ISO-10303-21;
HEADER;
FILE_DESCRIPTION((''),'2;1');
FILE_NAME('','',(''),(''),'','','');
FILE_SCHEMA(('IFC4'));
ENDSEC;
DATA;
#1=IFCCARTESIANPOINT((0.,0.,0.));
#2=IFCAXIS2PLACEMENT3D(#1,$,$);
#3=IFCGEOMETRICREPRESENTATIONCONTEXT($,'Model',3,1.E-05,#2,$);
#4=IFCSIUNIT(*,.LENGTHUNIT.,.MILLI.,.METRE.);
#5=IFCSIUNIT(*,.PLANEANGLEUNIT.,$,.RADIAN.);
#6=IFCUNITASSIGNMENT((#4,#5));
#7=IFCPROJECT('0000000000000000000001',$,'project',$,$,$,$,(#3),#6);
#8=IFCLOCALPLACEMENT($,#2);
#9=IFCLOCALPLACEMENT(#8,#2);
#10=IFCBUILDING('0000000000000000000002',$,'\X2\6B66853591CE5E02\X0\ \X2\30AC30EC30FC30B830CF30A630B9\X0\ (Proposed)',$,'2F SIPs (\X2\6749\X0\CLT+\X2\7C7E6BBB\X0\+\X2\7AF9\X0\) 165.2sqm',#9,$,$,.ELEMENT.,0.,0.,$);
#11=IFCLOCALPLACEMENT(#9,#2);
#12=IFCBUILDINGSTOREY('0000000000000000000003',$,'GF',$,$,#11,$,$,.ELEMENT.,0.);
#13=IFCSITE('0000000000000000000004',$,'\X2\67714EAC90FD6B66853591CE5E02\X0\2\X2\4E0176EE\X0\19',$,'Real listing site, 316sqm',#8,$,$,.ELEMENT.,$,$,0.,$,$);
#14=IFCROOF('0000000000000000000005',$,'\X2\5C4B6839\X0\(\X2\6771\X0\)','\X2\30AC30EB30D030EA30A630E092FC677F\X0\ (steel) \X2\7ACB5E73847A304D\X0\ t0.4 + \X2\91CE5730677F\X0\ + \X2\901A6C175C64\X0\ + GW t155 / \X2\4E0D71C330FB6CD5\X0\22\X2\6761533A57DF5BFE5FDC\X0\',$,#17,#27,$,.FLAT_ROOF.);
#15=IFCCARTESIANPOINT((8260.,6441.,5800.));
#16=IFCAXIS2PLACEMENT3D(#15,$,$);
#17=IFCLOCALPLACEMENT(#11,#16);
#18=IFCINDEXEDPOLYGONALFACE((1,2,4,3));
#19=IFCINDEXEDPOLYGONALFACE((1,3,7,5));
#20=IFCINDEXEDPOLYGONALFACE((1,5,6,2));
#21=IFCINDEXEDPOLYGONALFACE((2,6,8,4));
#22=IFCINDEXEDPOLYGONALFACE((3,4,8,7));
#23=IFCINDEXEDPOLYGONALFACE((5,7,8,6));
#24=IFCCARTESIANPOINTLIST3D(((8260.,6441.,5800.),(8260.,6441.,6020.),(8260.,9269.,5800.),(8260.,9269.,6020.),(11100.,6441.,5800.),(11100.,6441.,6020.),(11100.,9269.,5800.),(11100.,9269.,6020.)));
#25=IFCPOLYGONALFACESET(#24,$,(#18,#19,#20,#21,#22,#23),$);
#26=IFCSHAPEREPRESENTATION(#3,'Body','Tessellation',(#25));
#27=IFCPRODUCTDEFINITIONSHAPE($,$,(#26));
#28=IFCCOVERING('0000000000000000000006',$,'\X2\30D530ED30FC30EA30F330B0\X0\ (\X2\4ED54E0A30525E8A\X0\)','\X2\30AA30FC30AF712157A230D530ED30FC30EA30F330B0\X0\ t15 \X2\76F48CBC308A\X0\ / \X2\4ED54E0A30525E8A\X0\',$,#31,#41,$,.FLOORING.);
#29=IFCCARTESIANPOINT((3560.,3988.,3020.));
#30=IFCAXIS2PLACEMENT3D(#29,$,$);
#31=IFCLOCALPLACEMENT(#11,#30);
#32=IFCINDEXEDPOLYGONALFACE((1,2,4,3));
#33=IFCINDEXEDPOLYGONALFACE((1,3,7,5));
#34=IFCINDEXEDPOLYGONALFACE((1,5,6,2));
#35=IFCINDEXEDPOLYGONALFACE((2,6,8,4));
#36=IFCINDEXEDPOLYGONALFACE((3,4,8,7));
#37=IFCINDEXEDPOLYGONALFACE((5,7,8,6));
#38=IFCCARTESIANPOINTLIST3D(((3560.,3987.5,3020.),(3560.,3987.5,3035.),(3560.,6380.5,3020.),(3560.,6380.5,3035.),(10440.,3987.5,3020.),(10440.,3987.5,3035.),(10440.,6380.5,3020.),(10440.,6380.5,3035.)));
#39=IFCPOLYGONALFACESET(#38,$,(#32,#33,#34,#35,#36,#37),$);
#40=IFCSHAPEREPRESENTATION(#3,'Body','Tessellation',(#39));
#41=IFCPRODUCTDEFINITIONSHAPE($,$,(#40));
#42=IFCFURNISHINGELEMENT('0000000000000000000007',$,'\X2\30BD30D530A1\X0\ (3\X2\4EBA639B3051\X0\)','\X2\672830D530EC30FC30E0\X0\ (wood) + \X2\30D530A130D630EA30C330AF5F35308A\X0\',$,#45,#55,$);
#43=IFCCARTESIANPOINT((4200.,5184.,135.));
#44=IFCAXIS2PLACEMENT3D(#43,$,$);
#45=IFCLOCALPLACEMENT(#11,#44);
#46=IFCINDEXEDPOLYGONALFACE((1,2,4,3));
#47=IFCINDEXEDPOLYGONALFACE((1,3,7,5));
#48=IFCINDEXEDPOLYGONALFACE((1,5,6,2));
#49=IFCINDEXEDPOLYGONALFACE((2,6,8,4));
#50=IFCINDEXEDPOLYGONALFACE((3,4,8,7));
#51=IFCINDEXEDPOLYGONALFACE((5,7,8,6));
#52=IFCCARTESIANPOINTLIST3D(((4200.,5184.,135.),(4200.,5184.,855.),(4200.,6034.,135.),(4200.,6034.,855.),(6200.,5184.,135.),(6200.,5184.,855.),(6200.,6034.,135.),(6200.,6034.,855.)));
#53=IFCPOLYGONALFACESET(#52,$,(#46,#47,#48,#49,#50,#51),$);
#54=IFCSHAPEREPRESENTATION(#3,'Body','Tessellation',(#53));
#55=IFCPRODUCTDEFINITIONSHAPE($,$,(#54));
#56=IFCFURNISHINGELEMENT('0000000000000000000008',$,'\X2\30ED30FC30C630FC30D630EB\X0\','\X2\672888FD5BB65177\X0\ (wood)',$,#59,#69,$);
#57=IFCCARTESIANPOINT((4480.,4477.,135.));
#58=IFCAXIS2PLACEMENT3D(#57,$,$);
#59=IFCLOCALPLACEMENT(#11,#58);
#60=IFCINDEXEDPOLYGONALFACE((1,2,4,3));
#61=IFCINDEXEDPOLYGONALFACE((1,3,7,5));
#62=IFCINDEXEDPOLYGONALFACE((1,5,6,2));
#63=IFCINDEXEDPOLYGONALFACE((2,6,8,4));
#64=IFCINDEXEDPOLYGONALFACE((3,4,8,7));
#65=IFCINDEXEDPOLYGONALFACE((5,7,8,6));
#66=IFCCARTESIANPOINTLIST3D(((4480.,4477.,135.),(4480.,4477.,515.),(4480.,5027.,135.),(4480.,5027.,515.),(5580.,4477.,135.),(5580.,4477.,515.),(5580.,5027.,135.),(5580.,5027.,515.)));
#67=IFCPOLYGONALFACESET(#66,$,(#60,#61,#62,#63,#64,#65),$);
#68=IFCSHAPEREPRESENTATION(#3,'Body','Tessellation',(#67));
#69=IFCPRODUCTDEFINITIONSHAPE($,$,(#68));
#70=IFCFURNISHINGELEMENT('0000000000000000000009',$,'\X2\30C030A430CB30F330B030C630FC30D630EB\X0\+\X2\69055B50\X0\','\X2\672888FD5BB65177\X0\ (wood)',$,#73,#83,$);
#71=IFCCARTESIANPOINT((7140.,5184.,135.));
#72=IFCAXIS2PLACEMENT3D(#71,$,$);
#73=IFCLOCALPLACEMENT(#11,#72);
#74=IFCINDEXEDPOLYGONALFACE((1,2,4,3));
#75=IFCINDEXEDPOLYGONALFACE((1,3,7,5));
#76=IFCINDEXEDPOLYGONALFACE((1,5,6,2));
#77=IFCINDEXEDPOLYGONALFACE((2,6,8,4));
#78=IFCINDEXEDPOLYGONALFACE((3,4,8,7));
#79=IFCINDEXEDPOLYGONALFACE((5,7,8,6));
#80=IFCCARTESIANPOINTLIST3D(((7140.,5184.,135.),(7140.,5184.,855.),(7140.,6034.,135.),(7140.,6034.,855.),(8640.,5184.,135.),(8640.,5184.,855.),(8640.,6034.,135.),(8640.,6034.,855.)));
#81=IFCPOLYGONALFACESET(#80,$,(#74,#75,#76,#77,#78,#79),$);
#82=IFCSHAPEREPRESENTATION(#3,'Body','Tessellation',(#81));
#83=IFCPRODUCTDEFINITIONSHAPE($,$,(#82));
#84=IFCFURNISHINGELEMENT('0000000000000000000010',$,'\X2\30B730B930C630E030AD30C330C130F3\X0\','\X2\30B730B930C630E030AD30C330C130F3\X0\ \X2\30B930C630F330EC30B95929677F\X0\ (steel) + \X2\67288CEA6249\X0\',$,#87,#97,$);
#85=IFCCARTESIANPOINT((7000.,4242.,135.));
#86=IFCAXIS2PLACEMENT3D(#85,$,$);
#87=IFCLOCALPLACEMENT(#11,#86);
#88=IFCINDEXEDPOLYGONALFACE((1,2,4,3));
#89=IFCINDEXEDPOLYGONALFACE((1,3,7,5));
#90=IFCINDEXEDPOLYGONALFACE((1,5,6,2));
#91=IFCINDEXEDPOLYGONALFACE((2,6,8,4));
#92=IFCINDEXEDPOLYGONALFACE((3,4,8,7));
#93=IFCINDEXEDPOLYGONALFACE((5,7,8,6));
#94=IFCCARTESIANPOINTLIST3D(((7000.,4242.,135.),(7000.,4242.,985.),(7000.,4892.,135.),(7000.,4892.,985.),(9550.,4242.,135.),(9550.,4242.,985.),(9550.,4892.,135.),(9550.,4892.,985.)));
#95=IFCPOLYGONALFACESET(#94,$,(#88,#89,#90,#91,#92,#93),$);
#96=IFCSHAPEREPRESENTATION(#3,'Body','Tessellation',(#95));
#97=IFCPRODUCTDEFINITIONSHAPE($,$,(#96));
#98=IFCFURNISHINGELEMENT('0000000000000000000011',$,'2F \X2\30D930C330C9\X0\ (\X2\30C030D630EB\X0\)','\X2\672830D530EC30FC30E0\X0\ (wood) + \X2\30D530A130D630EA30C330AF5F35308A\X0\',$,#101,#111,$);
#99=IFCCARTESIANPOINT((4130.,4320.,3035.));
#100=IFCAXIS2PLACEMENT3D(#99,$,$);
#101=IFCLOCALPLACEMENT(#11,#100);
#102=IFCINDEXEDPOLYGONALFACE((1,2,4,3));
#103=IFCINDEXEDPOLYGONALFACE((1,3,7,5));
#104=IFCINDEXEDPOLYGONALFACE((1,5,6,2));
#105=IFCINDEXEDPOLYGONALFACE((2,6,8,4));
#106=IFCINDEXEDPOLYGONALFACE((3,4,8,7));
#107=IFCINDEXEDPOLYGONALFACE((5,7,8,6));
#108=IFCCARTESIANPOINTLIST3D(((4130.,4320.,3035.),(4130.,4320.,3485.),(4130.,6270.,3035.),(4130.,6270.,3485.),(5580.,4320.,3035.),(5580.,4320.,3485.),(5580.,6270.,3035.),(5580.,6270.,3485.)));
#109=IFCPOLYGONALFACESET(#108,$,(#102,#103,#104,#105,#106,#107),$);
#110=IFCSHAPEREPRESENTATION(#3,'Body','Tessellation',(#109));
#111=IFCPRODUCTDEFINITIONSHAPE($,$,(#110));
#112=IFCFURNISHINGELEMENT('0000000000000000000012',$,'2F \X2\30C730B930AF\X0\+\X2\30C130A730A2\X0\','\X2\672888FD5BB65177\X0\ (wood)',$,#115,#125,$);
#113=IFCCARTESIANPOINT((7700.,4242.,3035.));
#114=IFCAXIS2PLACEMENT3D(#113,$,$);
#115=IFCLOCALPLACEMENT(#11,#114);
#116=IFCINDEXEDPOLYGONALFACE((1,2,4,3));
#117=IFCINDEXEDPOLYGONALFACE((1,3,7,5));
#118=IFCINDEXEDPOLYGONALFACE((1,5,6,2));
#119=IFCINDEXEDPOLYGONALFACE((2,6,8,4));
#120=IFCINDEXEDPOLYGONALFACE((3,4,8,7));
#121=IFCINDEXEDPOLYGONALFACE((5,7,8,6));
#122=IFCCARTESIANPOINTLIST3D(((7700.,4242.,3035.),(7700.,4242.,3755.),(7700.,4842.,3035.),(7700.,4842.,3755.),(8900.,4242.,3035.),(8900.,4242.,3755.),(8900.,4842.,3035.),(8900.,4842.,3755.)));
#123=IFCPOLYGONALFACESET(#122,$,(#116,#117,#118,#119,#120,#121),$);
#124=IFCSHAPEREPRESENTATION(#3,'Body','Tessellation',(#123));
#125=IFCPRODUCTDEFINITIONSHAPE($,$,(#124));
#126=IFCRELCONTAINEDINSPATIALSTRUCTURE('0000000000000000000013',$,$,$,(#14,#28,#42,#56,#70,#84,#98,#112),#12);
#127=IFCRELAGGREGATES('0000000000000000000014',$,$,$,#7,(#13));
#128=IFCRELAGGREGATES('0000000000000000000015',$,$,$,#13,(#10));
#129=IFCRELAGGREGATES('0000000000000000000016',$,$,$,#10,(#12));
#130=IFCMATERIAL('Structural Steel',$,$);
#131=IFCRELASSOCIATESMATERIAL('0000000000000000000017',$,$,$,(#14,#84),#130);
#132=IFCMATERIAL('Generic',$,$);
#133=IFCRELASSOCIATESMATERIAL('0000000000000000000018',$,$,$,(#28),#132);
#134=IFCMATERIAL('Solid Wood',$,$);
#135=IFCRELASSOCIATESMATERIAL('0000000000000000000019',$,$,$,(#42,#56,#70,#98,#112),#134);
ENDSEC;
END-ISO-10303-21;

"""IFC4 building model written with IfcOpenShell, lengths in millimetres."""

from ifc_helpers import new_model, si_unit, frame, frame_2d, origin, place, context, project, spatial, rectangle, extrude, material, element, save


model = new_model("IFC4")

# Units and contexts
model_context = context("Model", 3, precision=1e-05, world=origin())
ifc_project = project(units=[si_unit("LENGTHUNIT", "METRE", prefix="MILLI"), si_unit("PLANEANGLEUNIT", "RADIAN")], contexts=[model_context])

# Site, building, storey
site_placement = place(None, origin())
site = spatial("IfcSite", under=ifc_project, at=site_placement, Name="東京都武蔵野市2丁目19", ObjectType="Real listing site, 316sqm", CompositionType="ELEMENT", RefElevation=0.0)
building_placement = place(site_placement, origin())
building = spatial("IfcBuilding", under=site, at=building_placement, Name="武蔵野市 ガレージハウス (Proposed)", ObjectType="2F SIPs (杉CLT+籾殻+竹) 165.2sqm", CompositionType="ELEMENT", ElevationOfRefHeight=0.0, ElevationOfTerrain=0.0)
storey_placement = place(building_placement, origin())
storey = spatial("IfcBuildingStorey", under=building, at=storey_placement, Name="GF", CompositionType="ELEMENT", Elevation=0.0)

# Shared definitions
ifc_material_1 = material(Name="Solid Wood")

# Shared definitions
ifc_material_2 = material(Name="Generic")

# Roof
ifc_material_3 = material(Name="Structural Steel")
roof_placement = place(storey_placement, frame((8260.0, 6441.0, 5800.0)))
element("IfcRoof", 1, at=roof_placement, inside=storey, material=ifc_material_3, Name="屋根(東)", Description="ガルバリウム鋼板 (steel) 立平葺き t0.4 + 野地板 + 通気層 + GW t155 / 不燃・法22条区域対応", PredefinedType="FLAT_ROOF", context=model_context, shape_type="SweptSolid", body=[
    extrude(rectangle(XDim=2840.0, YDim=2828.0, at=frame_2d((1420.0, 1414.0))), frame((8260.0, 6441.0, 5800.0)), (0.0, 0.0, 1.0), 220.0),
])

# Covering
covering_placement = place(storey_placement, frame((3560.0, 3988.0, 3020.0)))
element("IfcCovering", 2, at=covering_placement, inside=storey, material=ifc_material_2, Name="フローリング (仕上げ床)", Description="オーク無垢フローリング t15 直貼り / 仕上げ床", PredefinedType="FLOORING", context=model_context, shape_type="SweptSolid", body=[
    extrude(rectangle(XDim=6880.0, YDim=2393.0, at=frame_2d((3440.0, 1196.0))), frame((3560.0, 3988.0, 3020.0)), (0.0, 0.0, 1.0), 15.0),
])

# Furnishing elements
furnishing_1_placement = place(storey_placement, frame((4200.0, 5184.0, 135.0)))
element("IfcFurnishingElement", 3, at=furnishing_1_placement, inside=storey, material=ifc_material_1, Name="ソファ (3人掛け)", Description="木フレーム (wood) + ファブリック張り", context=model_context, shape_type="SweptSolid", body=[
    extrude(rectangle(XDim=2000.0, YDim=850.0, at=frame_2d((1000.0, 425.0))), frame((4200.0, 5184.0, 135.0)), (0.0, 0.0, 1.0), 720.0),
])
furnishing_2_placement = place(storey_placement, frame((4480.0, 4477.0, 135.0)))
element("IfcFurnishingElement", 4, at=furnishing_2_placement, inside=storey, material=ifc_material_1, Name="ローテーブル", Description="木製家具 (wood)", context=model_context, shape_type="SweptSolid", body=[
    extrude(rectangle(XDim=1100.0, YDim=550.0, at=frame_2d((550.0, 275.0))), frame((4480.0, 4477.0, 135.0)), (0.0, 0.0, 1.0), 380.0),
])
furnishing_3_placement = place(storey_placement, frame((7140.0, 5184.0, 135.0)))
element("IfcFurnishingElement", 5, at=furnishing_3_placement, inside=storey, material=ifc_material_1, Name="ダイニングテーブル+椅子", Description="木製家具 (wood)", context=model_context, shape_type="SweptSolid", body=[
    extrude(rectangle(XDim=1500.0, YDim=850.0, at=frame_2d((750.0, 425.0))), frame((7140.0, 5184.0, 135.0)), (0.0, 0.0, 1.0), 720.0),
])
furnishing_4_placement = place(storey_placement, frame((7000.0, 4242.0, 135.0)))
element("IfcFurnishingElement", 6, at=furnishing_4_placement, inside=storey, material=ifc_material_3, Name="システムキッチン", Description="システムキッチン ステンレス天板 (steel) + 木質扉", context=model_context, shape_type="SweptSolid", body=[
    extrude(rectangle(XDim=2550.0, YDim=650.0, at=frame_2d((1275.0, 325.0))), frame((7000.0, 4242.0, 135.0)), (0.0, 0.0, 1.0), 850.0),
])
furnishing_5_placement = place(storey_placement, frame((4130.0, 4320.0, 3035.0)))
element("IfcFurnishingElement", 7, at=furnishing_5_placement, inside=storey, material=ifc_material_1, Name="2F ベッド (ダブル)", Description="木フレーム (wood) + ファブリック張り", context=model_context, shape_type="SweptSolid", body=[
    extrude(rectangle(XDim=1450.0, YDim=1950.0, at=frame_2d((725.0, 975.0))), frame((4130.0, 4320.0, 3035.0)), (0.0, 0.0, 1.0), 450.0),
])
furnishing_6_placement = place(storey_placement, frame((7700.0, 4242.0, 3035.0)))
element("IfcFurnishingElement", 8, at=furnishing_6_placement, inside=storey, material=ifc_material_1, Name="2F デスク+チェア", Description="木製家具 (wood)", context=model_context, shape_type="SweptSolid", body=[
    extrude(rectangle(XDim=1200.0, YDim=600.0, at=frame_2d((600.0, 300.0))), frame((7700.0, 4242.0, 3035.0)), (0.0, 0.0, 1.0), 720.0),
])

save(model, "model.ifc")
